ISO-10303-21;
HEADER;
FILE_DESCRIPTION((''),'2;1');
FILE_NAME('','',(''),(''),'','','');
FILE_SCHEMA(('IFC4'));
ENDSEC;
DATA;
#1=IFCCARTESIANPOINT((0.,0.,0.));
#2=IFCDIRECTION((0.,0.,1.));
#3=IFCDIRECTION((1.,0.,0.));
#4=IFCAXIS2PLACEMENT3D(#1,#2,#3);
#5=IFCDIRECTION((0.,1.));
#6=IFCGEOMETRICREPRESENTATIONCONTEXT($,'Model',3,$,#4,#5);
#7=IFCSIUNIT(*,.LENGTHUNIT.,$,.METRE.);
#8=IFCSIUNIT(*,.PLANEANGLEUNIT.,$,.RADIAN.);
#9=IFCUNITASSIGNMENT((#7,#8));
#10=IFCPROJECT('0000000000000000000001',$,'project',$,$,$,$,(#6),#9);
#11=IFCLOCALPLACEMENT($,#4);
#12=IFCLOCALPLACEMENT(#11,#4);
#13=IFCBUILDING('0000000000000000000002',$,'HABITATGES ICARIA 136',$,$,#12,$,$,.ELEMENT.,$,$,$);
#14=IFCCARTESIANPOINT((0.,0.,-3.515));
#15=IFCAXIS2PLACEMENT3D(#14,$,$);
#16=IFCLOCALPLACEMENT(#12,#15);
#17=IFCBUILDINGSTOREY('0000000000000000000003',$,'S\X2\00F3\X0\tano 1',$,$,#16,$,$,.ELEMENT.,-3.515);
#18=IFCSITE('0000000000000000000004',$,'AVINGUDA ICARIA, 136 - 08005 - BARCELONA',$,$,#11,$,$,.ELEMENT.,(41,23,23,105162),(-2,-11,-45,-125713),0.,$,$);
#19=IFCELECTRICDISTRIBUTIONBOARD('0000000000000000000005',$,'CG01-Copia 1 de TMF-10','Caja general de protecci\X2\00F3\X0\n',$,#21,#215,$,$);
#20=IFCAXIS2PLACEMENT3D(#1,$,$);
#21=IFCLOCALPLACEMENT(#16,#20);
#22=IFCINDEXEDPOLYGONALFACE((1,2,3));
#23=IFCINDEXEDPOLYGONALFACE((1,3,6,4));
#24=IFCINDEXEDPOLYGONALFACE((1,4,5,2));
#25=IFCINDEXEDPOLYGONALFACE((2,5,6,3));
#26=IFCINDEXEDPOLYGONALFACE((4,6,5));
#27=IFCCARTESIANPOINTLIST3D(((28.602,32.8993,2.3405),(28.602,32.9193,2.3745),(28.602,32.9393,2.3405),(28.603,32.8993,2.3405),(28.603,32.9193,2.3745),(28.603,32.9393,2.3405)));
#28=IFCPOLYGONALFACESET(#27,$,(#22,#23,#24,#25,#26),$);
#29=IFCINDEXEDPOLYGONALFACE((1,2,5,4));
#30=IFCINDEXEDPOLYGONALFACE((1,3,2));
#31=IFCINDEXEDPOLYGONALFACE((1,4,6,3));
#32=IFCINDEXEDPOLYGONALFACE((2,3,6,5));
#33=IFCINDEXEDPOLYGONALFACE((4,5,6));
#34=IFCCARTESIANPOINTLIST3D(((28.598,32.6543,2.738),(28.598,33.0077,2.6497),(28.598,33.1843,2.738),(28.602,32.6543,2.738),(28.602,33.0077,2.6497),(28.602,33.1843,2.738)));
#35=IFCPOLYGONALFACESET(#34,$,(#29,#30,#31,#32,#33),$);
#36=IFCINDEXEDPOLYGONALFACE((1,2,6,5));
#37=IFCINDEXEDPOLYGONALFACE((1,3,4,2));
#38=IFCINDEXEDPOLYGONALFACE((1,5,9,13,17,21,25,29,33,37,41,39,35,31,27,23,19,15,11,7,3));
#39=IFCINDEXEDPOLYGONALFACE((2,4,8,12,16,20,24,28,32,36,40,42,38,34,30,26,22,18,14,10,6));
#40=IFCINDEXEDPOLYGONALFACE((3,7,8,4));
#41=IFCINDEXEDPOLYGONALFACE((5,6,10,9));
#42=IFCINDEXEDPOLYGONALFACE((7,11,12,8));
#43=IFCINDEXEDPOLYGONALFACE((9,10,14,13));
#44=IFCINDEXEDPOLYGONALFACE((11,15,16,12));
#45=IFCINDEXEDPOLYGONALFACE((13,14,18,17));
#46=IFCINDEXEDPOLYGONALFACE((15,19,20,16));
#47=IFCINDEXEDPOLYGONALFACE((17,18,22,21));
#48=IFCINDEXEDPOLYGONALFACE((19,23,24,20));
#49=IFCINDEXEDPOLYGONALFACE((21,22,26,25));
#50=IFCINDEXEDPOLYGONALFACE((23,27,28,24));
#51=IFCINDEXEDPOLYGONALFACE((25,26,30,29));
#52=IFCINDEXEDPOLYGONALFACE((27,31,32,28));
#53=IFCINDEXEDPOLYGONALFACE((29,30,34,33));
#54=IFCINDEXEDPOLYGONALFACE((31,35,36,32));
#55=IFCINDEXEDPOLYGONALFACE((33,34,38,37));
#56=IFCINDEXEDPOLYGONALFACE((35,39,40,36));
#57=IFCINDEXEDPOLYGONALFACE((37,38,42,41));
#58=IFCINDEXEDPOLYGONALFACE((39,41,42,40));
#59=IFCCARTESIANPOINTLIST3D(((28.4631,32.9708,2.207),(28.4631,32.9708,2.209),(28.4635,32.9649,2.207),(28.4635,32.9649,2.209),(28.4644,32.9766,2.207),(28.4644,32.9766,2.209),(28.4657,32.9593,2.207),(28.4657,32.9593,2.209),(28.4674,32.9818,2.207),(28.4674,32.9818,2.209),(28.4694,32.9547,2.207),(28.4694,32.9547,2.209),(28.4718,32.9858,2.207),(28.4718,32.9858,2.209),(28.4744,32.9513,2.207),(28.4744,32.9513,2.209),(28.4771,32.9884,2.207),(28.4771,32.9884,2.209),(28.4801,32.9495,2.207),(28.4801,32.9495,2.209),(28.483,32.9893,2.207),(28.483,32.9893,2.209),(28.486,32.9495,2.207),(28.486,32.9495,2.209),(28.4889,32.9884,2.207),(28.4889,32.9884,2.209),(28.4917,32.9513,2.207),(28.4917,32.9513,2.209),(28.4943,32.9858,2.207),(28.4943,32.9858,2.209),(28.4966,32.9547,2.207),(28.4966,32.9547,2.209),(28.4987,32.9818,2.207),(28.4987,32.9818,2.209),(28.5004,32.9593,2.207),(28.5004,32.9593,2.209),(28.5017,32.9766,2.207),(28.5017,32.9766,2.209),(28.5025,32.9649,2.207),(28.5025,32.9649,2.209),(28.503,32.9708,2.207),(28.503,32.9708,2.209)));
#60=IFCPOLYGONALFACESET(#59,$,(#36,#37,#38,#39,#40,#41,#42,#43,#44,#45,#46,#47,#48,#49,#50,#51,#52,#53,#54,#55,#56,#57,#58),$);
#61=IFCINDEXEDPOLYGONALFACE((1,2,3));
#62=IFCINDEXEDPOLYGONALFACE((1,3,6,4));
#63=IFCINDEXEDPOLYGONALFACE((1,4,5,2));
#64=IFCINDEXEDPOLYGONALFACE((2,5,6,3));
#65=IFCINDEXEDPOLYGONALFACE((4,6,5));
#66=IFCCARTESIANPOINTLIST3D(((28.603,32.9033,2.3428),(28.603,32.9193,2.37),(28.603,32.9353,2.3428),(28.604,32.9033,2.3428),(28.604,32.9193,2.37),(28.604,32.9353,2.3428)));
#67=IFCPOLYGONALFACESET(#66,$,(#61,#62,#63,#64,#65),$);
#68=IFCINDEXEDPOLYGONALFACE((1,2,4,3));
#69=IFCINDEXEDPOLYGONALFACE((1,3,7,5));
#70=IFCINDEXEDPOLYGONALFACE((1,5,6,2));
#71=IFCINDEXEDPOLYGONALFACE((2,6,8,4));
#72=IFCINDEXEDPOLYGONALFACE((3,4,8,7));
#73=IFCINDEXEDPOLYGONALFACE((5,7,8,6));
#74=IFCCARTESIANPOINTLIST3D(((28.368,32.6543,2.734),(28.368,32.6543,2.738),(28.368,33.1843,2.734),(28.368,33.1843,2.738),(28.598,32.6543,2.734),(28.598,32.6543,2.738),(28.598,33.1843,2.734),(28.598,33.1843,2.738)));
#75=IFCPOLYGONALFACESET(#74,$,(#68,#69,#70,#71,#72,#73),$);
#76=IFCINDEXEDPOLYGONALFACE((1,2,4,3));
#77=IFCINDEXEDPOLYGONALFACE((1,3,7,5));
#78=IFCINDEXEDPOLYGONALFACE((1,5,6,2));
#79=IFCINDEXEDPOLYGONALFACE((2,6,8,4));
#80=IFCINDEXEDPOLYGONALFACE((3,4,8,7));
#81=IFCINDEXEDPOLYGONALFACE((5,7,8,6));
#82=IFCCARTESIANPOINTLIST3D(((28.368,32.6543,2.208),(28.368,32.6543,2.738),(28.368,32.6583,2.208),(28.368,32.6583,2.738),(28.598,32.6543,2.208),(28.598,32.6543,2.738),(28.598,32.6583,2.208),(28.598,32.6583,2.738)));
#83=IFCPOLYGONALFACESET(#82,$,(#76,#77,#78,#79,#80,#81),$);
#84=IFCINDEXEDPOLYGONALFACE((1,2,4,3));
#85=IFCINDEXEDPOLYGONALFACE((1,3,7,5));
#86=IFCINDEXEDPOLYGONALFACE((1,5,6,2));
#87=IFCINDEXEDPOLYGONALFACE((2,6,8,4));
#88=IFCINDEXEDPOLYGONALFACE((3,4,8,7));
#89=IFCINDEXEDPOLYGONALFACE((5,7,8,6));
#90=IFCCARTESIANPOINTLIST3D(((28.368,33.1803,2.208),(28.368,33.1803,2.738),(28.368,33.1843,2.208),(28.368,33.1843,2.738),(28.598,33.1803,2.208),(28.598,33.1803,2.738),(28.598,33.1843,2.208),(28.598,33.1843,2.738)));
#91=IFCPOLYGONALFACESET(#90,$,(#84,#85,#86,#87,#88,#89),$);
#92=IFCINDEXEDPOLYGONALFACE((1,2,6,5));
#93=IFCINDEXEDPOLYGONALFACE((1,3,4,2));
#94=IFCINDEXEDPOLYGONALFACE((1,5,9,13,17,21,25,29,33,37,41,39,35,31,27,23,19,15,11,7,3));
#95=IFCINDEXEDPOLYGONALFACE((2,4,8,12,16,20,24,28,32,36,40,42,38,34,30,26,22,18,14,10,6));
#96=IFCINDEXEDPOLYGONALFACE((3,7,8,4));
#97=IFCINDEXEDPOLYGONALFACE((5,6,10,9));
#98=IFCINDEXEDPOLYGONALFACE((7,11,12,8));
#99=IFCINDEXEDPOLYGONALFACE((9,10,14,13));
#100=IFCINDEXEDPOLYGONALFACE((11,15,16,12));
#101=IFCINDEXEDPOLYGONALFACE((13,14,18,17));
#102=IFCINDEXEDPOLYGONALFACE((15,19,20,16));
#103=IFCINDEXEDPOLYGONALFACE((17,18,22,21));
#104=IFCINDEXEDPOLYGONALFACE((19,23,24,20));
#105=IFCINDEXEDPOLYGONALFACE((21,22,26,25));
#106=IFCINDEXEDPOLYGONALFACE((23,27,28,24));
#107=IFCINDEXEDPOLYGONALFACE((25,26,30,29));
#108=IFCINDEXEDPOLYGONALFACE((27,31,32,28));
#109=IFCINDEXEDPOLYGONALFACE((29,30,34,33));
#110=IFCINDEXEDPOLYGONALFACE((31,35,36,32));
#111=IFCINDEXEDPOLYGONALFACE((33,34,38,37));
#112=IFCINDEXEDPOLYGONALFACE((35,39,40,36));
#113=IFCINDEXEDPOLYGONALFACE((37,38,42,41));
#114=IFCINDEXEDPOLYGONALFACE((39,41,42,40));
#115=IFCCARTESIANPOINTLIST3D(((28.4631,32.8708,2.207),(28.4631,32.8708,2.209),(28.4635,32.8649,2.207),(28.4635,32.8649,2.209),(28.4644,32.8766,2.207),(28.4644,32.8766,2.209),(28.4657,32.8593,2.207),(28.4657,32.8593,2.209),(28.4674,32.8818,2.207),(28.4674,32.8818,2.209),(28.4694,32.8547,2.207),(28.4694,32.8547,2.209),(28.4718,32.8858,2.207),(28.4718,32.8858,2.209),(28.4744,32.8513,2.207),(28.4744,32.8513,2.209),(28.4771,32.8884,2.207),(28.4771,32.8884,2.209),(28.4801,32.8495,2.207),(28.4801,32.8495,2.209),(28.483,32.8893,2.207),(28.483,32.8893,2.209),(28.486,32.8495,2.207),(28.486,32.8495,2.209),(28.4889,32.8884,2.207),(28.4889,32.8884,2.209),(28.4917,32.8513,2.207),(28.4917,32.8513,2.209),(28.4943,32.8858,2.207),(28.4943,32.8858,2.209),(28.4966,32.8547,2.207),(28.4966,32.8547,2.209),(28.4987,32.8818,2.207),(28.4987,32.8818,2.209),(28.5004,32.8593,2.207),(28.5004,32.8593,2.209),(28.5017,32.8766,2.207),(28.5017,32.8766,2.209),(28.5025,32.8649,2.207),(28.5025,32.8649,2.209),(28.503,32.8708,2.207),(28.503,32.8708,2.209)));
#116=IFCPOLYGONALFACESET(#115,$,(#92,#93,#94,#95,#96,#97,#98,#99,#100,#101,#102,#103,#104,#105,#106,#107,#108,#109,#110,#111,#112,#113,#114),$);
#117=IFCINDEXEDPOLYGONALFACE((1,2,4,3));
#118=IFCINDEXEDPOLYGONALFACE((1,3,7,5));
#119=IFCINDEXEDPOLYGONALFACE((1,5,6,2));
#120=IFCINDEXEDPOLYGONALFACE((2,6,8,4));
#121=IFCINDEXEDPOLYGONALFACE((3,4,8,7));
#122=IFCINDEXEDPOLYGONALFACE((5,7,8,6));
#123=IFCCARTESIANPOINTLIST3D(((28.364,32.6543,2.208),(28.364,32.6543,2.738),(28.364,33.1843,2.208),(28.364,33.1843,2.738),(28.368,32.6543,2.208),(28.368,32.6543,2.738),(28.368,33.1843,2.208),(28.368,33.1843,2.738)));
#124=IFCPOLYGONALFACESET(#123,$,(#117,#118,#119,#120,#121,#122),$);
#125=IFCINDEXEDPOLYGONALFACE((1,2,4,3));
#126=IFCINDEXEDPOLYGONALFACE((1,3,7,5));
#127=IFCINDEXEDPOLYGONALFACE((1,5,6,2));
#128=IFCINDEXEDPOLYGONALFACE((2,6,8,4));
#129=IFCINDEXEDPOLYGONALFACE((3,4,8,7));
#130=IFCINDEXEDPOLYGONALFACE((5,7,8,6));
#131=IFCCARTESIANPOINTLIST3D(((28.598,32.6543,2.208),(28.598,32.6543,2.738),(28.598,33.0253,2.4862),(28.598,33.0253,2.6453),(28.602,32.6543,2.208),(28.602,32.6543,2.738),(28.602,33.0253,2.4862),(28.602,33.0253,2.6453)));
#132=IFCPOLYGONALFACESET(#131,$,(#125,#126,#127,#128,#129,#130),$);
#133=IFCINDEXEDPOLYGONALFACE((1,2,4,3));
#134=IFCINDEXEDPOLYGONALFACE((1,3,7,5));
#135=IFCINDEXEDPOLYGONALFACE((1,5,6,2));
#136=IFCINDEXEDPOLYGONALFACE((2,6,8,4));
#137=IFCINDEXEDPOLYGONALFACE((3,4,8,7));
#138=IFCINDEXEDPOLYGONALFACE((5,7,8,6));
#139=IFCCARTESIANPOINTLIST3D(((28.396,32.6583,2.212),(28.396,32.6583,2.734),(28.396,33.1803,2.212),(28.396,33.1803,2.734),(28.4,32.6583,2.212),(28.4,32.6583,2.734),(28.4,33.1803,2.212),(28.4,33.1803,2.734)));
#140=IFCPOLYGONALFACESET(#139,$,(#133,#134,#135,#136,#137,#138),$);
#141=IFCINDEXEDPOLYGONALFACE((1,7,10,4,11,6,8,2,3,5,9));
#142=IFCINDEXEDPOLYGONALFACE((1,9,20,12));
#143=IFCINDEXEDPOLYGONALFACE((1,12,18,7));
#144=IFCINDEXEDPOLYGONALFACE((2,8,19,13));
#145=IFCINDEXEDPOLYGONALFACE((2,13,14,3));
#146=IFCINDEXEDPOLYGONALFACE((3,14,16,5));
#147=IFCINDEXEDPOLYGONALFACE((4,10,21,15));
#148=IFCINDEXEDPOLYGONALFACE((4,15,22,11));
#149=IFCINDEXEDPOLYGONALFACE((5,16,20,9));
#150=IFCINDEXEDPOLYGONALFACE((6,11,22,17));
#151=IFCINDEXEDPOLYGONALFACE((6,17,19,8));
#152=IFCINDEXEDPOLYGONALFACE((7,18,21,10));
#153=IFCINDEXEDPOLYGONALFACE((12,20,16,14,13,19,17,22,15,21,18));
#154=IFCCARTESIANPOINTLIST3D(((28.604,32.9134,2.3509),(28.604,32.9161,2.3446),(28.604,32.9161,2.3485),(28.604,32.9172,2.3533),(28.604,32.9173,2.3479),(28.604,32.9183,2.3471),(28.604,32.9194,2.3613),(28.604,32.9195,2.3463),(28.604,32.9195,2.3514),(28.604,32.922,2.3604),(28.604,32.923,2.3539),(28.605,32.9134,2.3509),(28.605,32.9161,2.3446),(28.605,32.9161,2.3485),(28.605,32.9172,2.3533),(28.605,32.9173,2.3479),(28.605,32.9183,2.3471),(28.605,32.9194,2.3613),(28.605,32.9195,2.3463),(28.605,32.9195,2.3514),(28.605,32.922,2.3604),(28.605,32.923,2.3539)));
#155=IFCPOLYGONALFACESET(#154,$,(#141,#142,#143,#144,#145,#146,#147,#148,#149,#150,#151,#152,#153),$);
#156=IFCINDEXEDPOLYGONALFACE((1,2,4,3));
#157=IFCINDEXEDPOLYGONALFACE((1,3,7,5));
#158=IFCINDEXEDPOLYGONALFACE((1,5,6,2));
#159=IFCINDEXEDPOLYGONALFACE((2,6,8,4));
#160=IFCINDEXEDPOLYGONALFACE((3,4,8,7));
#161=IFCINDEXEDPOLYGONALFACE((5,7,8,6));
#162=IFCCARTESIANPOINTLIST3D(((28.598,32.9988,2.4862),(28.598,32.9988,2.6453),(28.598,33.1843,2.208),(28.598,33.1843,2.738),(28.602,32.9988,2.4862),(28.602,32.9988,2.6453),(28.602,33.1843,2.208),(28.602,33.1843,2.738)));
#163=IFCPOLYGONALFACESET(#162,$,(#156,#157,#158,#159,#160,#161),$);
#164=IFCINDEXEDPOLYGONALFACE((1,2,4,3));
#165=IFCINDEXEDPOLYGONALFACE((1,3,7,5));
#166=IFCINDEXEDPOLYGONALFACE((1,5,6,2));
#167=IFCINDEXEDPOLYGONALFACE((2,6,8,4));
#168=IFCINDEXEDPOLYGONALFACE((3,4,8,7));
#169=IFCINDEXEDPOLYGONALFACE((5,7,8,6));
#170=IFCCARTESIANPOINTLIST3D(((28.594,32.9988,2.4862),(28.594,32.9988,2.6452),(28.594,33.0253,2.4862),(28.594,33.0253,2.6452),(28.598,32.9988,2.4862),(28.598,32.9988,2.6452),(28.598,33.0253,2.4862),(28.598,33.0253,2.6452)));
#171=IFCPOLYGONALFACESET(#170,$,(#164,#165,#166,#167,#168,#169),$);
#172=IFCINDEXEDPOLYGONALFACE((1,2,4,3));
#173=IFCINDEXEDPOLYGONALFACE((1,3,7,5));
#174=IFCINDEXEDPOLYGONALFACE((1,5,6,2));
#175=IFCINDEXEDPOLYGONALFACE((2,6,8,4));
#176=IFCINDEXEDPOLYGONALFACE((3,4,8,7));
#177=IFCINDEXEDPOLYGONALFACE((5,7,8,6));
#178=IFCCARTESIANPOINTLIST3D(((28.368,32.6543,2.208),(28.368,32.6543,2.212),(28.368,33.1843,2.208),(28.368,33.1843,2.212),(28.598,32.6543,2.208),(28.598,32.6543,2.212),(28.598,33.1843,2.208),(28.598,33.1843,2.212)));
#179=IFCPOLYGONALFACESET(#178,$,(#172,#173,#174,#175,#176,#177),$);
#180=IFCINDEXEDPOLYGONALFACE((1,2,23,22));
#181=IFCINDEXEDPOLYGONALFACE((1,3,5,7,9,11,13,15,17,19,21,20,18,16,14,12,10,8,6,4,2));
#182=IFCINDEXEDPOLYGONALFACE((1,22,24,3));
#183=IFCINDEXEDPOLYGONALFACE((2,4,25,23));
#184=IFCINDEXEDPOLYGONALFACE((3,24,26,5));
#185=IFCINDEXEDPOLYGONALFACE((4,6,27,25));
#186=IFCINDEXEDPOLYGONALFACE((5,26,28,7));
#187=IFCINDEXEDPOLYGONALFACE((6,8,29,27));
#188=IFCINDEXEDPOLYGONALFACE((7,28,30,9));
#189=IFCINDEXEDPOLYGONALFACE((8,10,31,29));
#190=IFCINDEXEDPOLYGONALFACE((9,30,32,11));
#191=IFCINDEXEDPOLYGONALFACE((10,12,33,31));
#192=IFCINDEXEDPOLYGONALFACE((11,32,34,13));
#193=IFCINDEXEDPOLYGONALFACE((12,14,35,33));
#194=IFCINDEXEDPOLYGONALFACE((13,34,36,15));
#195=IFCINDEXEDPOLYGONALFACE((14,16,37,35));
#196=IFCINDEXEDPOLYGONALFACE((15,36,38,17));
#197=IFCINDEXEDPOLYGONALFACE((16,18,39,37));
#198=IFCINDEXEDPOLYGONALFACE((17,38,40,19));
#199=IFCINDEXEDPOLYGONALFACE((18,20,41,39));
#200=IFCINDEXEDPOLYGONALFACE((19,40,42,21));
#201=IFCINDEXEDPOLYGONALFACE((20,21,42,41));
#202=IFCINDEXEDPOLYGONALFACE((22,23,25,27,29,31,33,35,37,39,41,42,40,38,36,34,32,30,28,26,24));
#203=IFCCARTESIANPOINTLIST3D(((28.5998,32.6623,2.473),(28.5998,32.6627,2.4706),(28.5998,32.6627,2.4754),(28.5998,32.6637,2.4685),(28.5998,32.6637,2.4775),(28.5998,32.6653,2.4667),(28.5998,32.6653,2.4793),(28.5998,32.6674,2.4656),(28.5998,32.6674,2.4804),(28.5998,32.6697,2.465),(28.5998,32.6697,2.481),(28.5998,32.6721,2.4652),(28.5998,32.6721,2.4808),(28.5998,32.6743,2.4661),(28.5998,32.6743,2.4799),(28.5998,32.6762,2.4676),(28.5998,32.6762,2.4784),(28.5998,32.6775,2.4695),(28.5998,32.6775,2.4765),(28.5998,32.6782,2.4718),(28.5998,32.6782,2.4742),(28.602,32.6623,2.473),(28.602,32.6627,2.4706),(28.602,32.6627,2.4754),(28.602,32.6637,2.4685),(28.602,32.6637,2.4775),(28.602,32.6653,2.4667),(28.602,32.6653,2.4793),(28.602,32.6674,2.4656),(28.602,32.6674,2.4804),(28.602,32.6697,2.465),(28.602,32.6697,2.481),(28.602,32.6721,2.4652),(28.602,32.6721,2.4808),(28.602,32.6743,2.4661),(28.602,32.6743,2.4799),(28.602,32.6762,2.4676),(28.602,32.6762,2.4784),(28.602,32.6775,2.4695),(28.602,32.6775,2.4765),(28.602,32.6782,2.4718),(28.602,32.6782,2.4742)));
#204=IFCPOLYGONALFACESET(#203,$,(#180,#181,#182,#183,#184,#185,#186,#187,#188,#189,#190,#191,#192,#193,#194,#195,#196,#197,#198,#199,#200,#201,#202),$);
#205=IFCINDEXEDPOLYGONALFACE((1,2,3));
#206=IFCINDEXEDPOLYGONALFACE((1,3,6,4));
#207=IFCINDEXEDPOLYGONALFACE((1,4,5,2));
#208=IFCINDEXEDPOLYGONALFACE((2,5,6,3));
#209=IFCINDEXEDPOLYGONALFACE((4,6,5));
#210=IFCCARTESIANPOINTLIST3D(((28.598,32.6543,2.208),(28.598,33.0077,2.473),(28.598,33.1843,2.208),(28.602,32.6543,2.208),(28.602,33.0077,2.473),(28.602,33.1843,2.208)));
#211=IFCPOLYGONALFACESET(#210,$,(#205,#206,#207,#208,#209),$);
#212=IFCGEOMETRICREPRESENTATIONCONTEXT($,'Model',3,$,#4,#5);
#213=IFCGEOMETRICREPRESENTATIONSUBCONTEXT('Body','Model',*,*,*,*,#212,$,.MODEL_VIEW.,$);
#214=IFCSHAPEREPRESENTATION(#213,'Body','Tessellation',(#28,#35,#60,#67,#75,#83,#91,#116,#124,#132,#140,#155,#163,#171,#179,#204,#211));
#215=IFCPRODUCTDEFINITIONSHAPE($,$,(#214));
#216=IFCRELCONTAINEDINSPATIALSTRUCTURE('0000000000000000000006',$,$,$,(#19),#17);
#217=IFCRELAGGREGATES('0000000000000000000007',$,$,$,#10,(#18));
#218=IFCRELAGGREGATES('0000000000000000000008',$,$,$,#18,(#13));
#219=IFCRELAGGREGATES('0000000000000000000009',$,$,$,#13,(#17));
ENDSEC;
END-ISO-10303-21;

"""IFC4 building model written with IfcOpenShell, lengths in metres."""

from ifc_helpers import new_model, si_unit, direction, frame, origin_with_axes, origin_2d_with_axis, place, context, subcontext, project, spatial, polyline, circle, outline, extrude, source, transform, mapped, element, save


model = new_model("IFC4")

# Units and contexts
model_context_1 = context("Model", 3, world=origin_with_axes(), true_north=direction((0.0, 1.0)))
model_context_2 = context("Model", 3, world=origin_with_axes(), true_north=direction((0.0, 1.0)))
body_context_1 = subcontext(model_context_2, "Body", "Model", "MODEL_VIEW")
ifc_project = project(units=[si_unit("LENGTHUNIT", "METRE"), si_unit("PLANEANGLEUNIT", "RADIAN")], contexts=[model_context_1])

# Site, building, storey
site_placement = place(None, origin_with_axes())
site = spatial("IfcSite", under=ifc_project, at=site_placement, Name="AVINGUDA ICARIA, 136 - 08005 - BARCELONA", CompositionType="ELEMENT", RefLatitude=(41, 23, 23, 105162), RefLongitude=(-2, -11, -45, -125713), RefElevation=0.0)
building_placement = place(site_placement, origin_with_axes())
building = spatial("IfcBuilding", under=site, at=building_placement, Name="HABITATGES ICARIA 136", CompositionType="ELEMENT")
storey_placement = place(building_placement, frame((0.0, 0.0, -3.515)))
storey = spatial("IfcBuildingStorey", under=building, at=storey_placement, Name="Sótano 1", CompositionType="ELEMENT", Elevation=-3.515)

# Shared definitions
placement_1 = place(None, origin_with_axes())
placement_2 = place(placement_1, origin_with_axes())
placement_3 = place(placement_2, frame((0.0, 0.0, -3.515)))

# Electric distribution board
shared_shape_1 = source(origin_with_axes(), body_context_1, "Body", "SweptSolid", [
    extrude(outline(polyline([(0.02, 0.1325), (0.0, 0.1665), (-0.02, 0.1325), (0.02, 0.1325)])), frame((0.0, -0.234, 0.0), z_axis=(0.0, -1.0, 0.0), x_axis=(1.0, 0.0, 0.0)), (0.0, 0.0, 1.0), 0.001),
    extrude(outline(polyline([(-0.265, 0.53), (0.265, 0.53), (-0.106, 0.4373), (-0.0795, 0.4373), (-0.265, 0.53)])), frame((0.0, -0.234, 0.0), z_axis=(0.0, 1.0, 0.0), x_axis=(-1.0, 0.0, 0.0)), (0.0, 0.0, 1.0), 0.004),
    extrude(circle(Radius=0.02, at=origin_2d_with_axis()), frame((0.05, -0.115, -0.001), z_axis=(0.0, 0.0, 1.0), x_axis=(1.0, 0.0, 0.0)), (0.0, 0.0, 1.0), 0.002),
    extrude(outline(polyline([(0.016, 0.1348), (0.0, 0.162), (-0.016, 0.1348), (0.016, 0.1348)])), frame((0.0, -0.235, 0.0), z_axis=(0.0, -1.0, 0.0), x_axis=(1.0, 0.0, 0.0)), (0.0, 0.0, 1.0), 0.001),
    extrude(outline(polyline([(-0.265, 0.0), (0.265, 0.0), (0.265, -0.23), (-0.265, -0.23), (-0.265, 0.0)])), frame((0.0, 0.0, 0.526), z_axis=(0.0, 0.0, 1.0), x_axis=(1.0, 0.0, 0.0)), (0.0, 0.0, 1.0), 0.004),
    extrude(outline(polyline([(-0.265, 0.0), (-0.261, 0.0), (-0.261, -0.23), (-0.265, -0.23), (-0.265, 0.0)])), origin_with_axes(), (0.0, 0.0, 1.0), 0.53),
    extrude(outline(polyline([(0.261, 0.0), (0.265, 0.0), (0.265, -0.23), (0.261, -0.23), (0.261, 0.0)])), origin_with_axes(), (0.0, 0.0, 1.0), 0.53),
    extrude(circle(Radius=0.02, at=origin_2d_with_axis()), frame((-0.05, -0.115, -0.001), z_axis=(0.0, 0.0, 1.0), x_axis=(1.0, 0.0, 0.0)), (0.0, 0.0, 1.0), 0.002),
    extrude(outline(polyline([(-0.265, 0.0), (0.265, 0.0), (0.265, 0.004), (-0.265, 0.004), (-0.265, 0.0)])), origin_with_axes(), (0.0, 0.0, 1.0), 0.53),
    extrude(outline(polyline([(0.265, 0.0), (-0.106, 0.2782), (-0.106, 0.4373), (0.265, 0.53), (0.265, 0.0)])), frame((0.0, -0.234, 0.0), z_axis=(0.0, 1.0, 0.0), x_axis=(-1.0, 0.0, 0.0)), (0.0, 0.0, 1.0), 0.004),
    extrude(outline(polyline([(-0.261, -0.032), (0.261, -0.032), (0.261, -0.028), (-0.261, -0.028), (-0.261, -0.032)])), frame((0.0, 0.0, 0.004), z_axis=(0.0, 0.0, 1.0), x_axis=(1.0, 0.0, 0.0)), (0.0, 0.0, 1.0), 0.522),
    extrude(outline(polyline([(0.0001, 0.1533), (-0.0059, 0.1429), (0.0002, 0.1434), (-0.002, 0.1399), (-0.0032, 0.1405), (-0.0032, 0.1366), (0.0001, 0.1383), (-0.001, 0.1391), (0.0037, 0.1459), (-0.0021, 0.1453), (0.0027, 0.1524), (0.0001, 0.1533)])), frame((0.0, -0.236, 0.0), z_axis=(0.0, -1.0, 0.0), x_axis=(1.0, 0.0, 0.0)), (0.0, 0.0, 1.0), 0.001),
    extrude(outline(polyline([(-0.265, 0.0), (-0.0795, 0.2782), (-0.0795, 0.4373), (-0.265, 0.53), (-0.265, 0.0)])), frame((0.0, -0.234, 0.0), z_axis=(0.0, 1.0, 0.0), x_axis=(-1.0, 0.0, 0.0)), (0.0, 0.0, 1.0), 0.004),
    extrude(outline(polyline([(0.106, -0.23), (0.0795, -0.23), (0.0795, -0.226), (0.106, -0.226), (0.106, -0.23)])), frame((0.0, 0.0, 0.2782), z_axis=(0.0, 0.0, 1.0), x_axis=(1.0, 0.0, 0.0)), (0.0, 0.0, 1.0), 0.159),
    extrude(outline(polyline([(-0.265, 0.0), (0.265, 0.0), (0.265, -0.23), (-0.265, -0.23), (-0.265, 0.0)])), origin_with_axes(), (0.0, 0.0, 1.0), 0.004),
    extrude(circle(Radius=0.008, at=origin_2d_with_axis()), frame((-0.249, -0.234, 0.265), z_axis=(0.0, 1.0, 0.0), x_axis=(-1.0, 0.0, 0.0)), (0.0, 0.0, 1.0), 0.0022),
    extrude(outline(polyline([(-0.265, 0.0), (0.265, 0.0), (-0.106, 0.2782), (-0.0795, 0.2782), (-0.265, 0.0)])), frame((0.0, -0.234, 0.0), z_axis=(0.0, 1.0, 0.0), x_axis=(-1.0, 0.0, 0.0)), (0.0, 0.0, 1.0), 0.004),
])
electric_distribution_board_1_placement = place(placement_3, origin_with_axes())
element("IfcElectricDistributionBoard", 1, at=electric_distribution_board_1_placement, inside=storey, Name="CG01-Copia 1 de TMF-10", Description="Caja general de protección", context=body_context_1, shape_type="MappedRepresentation", body=[
    mapped(shared_shape_1, transform((28.368, 32.9193, 2.208), x_axis=(0.0, 1.0, 0.0), y_axis=(-1.0, 0.0, 0.0), z_axis=(0.0, 0.0, 1.0), scale=1.0)),
])

save(model, "model.ifc")
